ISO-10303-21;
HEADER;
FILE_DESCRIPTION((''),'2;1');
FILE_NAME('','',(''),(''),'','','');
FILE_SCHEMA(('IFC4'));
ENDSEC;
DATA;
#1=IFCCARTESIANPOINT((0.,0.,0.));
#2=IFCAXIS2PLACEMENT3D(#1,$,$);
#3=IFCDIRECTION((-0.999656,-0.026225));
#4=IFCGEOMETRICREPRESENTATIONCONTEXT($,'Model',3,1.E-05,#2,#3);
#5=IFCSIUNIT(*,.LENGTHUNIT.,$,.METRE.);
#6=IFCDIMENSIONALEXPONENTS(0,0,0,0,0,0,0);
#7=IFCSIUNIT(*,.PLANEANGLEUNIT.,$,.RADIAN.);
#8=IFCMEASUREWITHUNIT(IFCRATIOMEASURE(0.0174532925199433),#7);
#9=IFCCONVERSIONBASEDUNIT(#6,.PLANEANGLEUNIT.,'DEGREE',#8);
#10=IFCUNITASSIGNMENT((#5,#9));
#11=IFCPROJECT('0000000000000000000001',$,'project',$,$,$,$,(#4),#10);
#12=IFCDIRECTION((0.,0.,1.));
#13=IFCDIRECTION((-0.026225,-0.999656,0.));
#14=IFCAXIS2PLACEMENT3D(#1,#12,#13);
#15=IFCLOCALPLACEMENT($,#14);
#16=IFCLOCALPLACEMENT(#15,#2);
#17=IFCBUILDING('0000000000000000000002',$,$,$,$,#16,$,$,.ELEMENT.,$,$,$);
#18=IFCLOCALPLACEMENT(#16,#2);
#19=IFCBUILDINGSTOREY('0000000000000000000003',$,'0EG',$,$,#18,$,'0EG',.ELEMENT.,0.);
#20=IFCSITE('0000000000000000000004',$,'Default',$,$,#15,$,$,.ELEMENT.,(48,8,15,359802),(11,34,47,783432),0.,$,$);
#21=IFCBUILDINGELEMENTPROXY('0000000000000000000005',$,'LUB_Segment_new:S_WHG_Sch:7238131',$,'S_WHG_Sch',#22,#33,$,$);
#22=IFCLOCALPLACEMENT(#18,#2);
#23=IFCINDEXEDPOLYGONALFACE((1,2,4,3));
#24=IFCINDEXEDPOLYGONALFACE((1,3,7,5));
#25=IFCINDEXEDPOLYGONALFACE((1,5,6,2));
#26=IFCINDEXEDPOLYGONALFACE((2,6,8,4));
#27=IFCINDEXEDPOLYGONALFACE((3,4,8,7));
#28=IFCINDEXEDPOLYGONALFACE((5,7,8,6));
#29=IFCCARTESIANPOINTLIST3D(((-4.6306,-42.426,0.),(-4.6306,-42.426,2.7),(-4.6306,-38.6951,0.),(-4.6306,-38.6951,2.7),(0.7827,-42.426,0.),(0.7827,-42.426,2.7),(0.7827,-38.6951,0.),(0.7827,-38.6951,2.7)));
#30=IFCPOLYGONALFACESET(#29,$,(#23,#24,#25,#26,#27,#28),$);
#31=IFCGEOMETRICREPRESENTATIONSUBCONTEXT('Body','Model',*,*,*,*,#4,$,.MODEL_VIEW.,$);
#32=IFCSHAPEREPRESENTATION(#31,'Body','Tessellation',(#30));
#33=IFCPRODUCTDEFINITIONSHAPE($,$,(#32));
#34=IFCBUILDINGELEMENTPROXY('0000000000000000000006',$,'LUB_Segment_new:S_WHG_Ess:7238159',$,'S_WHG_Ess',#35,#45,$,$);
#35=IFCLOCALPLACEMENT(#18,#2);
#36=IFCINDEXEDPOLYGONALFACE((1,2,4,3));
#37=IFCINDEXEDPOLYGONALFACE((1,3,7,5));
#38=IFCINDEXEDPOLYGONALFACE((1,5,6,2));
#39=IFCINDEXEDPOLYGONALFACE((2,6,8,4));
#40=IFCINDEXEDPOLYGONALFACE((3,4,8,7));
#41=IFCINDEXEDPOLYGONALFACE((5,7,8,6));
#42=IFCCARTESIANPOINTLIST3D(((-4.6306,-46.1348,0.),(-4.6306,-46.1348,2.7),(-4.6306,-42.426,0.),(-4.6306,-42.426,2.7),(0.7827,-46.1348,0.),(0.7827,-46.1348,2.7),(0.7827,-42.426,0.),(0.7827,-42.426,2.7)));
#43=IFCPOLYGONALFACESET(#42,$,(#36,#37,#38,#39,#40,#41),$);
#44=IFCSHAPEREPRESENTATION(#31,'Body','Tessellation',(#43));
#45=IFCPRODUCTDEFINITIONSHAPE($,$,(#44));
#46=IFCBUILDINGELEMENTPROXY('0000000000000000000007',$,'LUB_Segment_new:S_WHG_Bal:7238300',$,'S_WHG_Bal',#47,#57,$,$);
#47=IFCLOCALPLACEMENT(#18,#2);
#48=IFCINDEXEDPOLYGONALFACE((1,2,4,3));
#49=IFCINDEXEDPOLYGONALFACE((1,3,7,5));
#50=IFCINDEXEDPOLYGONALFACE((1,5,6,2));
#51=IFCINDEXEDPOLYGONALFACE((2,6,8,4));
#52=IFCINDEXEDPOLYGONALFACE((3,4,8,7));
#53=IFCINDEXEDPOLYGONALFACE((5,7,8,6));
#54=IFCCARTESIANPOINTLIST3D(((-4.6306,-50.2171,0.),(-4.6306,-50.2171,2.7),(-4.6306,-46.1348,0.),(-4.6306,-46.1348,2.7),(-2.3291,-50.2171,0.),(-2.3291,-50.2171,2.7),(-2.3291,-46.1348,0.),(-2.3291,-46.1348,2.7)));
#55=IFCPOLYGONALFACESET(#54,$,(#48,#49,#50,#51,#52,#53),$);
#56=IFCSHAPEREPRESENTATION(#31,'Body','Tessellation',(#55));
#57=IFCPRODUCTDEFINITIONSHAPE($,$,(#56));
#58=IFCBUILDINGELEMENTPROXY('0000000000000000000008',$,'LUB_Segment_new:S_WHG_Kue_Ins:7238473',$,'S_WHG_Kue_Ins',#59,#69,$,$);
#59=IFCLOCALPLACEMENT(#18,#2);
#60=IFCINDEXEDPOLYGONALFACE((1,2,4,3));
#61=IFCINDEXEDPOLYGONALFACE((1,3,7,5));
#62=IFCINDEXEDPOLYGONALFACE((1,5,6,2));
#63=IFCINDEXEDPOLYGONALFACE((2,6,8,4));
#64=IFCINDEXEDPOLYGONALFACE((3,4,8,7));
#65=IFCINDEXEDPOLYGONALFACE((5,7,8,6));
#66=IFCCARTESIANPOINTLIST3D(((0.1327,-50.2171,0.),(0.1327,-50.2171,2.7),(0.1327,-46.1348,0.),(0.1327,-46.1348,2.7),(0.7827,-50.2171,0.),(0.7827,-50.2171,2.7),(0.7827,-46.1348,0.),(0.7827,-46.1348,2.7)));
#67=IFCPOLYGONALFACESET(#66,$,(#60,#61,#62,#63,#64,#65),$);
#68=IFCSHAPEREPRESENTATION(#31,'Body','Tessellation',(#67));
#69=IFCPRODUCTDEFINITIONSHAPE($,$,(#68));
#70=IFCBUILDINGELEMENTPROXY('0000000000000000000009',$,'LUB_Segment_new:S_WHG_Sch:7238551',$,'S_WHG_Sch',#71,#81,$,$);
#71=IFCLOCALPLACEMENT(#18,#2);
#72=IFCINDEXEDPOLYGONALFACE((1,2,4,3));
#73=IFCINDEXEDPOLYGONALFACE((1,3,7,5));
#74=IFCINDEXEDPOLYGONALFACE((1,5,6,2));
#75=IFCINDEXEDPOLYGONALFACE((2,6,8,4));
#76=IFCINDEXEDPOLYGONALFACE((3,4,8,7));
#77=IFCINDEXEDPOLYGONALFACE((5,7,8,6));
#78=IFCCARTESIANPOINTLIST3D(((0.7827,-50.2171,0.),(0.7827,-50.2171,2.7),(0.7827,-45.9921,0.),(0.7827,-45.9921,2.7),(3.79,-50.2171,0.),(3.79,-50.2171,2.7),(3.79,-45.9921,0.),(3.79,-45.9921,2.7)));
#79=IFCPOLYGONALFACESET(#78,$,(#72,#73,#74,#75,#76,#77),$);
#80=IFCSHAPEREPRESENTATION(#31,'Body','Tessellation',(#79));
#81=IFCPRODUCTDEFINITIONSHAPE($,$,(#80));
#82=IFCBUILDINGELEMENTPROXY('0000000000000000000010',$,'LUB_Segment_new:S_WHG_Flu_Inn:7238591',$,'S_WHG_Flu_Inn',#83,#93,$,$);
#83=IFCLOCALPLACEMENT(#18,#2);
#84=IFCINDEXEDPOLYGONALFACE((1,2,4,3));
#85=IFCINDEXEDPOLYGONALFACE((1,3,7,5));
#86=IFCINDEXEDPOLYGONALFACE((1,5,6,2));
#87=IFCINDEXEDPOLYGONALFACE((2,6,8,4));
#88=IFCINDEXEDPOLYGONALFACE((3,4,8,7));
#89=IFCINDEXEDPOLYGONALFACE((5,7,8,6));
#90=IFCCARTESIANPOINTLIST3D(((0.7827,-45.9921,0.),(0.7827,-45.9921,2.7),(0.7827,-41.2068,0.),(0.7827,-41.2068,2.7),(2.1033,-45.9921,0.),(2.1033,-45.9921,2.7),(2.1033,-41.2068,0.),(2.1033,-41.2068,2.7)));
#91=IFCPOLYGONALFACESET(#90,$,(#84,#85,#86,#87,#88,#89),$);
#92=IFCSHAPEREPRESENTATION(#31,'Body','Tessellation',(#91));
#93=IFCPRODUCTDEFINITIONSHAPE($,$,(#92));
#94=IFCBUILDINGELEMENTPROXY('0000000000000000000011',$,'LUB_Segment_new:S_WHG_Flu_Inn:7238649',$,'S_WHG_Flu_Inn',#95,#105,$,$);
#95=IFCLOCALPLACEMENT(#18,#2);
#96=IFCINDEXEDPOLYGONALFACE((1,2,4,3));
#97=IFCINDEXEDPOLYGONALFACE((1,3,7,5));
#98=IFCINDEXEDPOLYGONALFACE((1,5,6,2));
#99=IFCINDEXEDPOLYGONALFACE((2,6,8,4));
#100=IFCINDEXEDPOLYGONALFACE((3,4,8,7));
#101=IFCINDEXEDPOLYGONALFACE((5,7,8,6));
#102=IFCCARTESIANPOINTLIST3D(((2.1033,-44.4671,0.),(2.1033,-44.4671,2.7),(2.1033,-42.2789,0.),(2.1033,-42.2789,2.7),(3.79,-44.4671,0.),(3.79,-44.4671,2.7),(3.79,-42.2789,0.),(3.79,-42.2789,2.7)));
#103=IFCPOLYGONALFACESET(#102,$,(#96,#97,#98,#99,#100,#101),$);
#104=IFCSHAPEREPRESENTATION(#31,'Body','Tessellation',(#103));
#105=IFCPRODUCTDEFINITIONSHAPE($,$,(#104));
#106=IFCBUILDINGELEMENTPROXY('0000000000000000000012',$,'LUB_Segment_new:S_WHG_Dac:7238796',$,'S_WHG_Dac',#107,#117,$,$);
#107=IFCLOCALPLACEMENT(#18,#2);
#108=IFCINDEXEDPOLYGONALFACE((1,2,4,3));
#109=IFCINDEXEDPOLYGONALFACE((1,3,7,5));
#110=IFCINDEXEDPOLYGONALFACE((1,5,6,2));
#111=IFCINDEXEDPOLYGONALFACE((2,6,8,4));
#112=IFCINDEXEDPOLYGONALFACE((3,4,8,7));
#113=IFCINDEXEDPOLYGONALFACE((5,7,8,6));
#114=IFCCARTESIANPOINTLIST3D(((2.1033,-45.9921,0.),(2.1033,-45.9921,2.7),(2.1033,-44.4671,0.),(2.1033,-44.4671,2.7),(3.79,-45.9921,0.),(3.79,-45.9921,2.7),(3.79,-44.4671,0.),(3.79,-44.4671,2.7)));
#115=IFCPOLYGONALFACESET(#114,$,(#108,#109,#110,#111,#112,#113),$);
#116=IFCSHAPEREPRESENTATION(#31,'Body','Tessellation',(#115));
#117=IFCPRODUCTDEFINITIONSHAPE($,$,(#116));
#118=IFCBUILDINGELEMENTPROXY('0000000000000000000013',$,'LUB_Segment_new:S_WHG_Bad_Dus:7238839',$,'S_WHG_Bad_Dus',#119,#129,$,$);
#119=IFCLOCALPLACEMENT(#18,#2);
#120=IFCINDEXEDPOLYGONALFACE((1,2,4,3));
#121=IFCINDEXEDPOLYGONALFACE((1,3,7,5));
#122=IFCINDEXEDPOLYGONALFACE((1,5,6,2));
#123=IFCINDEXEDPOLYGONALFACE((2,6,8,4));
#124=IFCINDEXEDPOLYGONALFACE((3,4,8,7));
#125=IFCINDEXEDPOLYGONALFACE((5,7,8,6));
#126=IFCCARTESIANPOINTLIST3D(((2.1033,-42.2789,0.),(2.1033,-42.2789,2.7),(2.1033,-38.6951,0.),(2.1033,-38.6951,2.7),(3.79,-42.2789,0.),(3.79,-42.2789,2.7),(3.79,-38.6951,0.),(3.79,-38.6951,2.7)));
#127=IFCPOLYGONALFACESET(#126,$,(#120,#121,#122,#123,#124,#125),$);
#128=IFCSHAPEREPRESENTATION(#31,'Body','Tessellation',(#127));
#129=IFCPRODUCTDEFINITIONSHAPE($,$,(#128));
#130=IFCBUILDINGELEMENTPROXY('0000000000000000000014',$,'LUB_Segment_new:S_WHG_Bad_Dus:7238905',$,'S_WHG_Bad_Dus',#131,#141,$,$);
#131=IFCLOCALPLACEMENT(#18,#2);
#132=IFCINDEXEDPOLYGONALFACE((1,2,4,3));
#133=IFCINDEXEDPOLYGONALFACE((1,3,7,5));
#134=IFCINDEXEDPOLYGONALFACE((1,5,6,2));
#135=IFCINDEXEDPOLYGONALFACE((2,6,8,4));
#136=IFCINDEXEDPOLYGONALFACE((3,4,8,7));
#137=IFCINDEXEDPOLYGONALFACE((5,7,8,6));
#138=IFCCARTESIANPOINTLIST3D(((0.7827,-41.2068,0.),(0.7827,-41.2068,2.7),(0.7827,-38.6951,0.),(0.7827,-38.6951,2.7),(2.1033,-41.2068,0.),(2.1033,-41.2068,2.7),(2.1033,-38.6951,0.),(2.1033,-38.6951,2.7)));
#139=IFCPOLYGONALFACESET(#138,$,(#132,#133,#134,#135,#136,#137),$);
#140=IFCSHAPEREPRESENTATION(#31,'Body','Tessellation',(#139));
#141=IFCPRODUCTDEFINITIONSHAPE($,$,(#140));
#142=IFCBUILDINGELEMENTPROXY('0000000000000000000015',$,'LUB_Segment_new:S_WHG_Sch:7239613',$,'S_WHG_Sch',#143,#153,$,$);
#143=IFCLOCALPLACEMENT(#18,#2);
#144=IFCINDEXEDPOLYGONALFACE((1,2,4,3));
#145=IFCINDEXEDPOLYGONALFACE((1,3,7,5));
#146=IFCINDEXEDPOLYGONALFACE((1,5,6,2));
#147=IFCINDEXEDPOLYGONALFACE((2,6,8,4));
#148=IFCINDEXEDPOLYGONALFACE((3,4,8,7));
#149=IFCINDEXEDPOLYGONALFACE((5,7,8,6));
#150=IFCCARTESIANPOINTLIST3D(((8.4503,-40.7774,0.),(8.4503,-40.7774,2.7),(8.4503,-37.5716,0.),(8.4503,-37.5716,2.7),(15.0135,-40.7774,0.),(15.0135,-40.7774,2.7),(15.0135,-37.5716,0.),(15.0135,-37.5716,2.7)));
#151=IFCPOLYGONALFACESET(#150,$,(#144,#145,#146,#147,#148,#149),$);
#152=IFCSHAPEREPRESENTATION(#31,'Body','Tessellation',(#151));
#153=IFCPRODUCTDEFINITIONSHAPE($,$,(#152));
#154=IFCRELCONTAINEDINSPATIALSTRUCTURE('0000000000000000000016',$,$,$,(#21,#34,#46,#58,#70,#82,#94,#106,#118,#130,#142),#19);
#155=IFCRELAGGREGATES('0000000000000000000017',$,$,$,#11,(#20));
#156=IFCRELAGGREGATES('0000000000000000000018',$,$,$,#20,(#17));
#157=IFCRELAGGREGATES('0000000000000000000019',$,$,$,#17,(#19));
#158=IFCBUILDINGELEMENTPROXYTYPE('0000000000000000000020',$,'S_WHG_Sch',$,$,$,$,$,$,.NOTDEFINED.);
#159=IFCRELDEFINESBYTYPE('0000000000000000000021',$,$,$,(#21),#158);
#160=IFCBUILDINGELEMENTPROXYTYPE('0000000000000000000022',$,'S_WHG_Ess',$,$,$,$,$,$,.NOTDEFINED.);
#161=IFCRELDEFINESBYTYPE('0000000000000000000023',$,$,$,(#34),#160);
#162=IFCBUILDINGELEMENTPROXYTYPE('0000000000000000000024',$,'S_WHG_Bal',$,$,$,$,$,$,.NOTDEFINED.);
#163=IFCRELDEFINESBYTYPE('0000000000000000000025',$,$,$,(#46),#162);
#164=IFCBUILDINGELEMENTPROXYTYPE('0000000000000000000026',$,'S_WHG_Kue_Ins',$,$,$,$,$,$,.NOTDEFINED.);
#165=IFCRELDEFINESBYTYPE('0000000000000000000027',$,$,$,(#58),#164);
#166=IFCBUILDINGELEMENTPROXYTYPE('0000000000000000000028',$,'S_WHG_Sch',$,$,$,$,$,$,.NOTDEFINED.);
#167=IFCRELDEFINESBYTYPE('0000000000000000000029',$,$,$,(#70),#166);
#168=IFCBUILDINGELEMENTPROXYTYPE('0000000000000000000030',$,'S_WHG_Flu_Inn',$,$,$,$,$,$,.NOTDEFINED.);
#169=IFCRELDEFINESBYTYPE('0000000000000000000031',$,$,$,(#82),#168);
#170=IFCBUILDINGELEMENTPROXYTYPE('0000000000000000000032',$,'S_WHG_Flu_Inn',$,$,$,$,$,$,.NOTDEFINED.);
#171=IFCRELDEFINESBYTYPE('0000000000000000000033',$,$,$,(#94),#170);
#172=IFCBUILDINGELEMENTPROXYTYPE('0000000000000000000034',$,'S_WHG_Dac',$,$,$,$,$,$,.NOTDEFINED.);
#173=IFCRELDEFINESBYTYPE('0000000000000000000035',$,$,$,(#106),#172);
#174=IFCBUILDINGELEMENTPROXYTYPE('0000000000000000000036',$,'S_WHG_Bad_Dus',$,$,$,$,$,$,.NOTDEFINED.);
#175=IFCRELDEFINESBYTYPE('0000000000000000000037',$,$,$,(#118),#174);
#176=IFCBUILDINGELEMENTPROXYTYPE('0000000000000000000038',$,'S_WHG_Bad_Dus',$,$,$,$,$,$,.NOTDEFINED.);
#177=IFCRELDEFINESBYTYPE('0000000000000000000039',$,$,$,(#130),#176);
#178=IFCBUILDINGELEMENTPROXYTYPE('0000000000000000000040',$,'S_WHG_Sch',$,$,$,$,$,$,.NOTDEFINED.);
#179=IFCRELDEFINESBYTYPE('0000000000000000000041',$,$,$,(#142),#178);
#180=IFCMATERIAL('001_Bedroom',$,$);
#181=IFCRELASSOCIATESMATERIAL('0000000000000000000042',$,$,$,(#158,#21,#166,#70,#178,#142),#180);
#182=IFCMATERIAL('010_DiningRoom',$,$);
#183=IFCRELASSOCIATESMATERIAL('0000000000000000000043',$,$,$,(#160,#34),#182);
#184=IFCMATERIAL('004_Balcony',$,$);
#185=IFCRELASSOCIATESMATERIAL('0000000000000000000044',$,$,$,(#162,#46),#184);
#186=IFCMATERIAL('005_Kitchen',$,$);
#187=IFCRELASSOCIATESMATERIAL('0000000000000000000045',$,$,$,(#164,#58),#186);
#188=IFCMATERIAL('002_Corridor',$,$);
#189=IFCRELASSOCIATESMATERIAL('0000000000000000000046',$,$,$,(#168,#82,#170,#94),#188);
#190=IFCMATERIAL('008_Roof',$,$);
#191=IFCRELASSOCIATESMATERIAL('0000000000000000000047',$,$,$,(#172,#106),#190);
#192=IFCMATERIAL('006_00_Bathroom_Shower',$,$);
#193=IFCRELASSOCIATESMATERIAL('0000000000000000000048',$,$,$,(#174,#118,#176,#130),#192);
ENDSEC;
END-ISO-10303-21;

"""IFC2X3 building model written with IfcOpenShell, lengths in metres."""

from ifc_helpers import new_model, entity, si_unit, converted_unit, direction, frame, frame_2d, origin, origin_2d_with_axis, place, context, subcontext, project, spatial, rectangle, extrude, source, transform, mapped, material, type_object, type_shapes, element, save


model = new_model("IFC2X3")

# Units and contexts
model_context = context("Model", 3, precision=1e-05, world=origin(), true_north=direction((-0.999656, -0.026225)))
body_context = subcontext(model_context, "Body", "Model", "MODEL_VIEW")
ifc_project = project(units=[si_unit("LENGTHUNIT", "METRE"), converted_unit("PLANEANGLEUNIT", "DEGREE", entity("IfcRatioMeasure", 0.0174532925199433), si_unit("PLANEANGLEUNIT", "RADIAN"), dimensions=[0, 0, 0, 0, 0, 0, 0])], contexts=[model_context])

# Site, building, storey
site_placement = place(None, frame((0.0, 0.0, 0.0), z_axis=(0.0, 0.0, 1.0), x_axis=(-0.026225, -0.999656, 0.0)))
site = spatial("IfcSite", under=ifc_project, at=site_placement, Name="Default", CompositionType="ELEMENT", RefLatitude=(48, 8, 15, 359802), RefLongitude=(11, 34, 47, 783432), RefElevation=0.0)
building_placement = place(site_placement, origin())
building = spatial("IfcBuilding", under=site, at=building_placement, CompositionType="ELEMENT")
storey_placement = place(building_placement, origin())
storey = spatial("IfcBuildingStorey", under=building, at=storey_placement, Name="0EG", LongName="0EG", CompositionType="ELEMENT", Elevation=0.0)

# Building element proxies
ifc_material_1 = material(Name="001_Bedroom")
building_element_proxy_type_1 = type_object("IfcBuildingElementProxyType", Name="S_WHG_Sch", PredefinedType="NOTDEFINED", material=ifc_material_1)
shared_shape_1 = source(origin(), body_context, "Body", "SweptSolid", [
    extrude(rectangle(XDim=5.4132, YDim=3.7309, at=origin_2d_with_axis()), frame((0.0, 0.0, 0.0), z_axis=(0.0, 0.0, 1.0), x_axis=(-1.0, 0.0, 0.0)), (0.0, 0.0, 1.0), 2.7),
])
type_shapes(building_element_proxy_type_1, [shared_shape_1])
proxy_1_placement = place(storey_placement, frame((-1.924, -40.5605, 0.0)))
element("IfcBuildingElementProxy", 1, at=proxy_1_placement, inside=storey, type_object=building_element_proxy_type_1, material=ifc_material_1, Name="LUB_Segment_new:S_WHG_Sch:7238131", ObjectType="S_WHG_Sch", context=body_context, shape_type="MappedRepresentation", body=[
    mapped(shared_shape_1, transform((0.0, 0.0, 0.0), scale=1.0)),
])
ifc_material_2 = material(Name="010_DiningRoom")
building_element_proxy_type_2 = type_object("IfcBuildingElementProxyType", Name="S_WHG_Ess", PredefinedType="NOTDEFINED", material=ifc_material_2)
shared_shape_2 = source(origin(), body_context, "Body", "SweptSolid", [
    extrude(rectangle(XDim=5.4132, YDim=3.7088, at=origin_2d_with_axis()), frame((0.0, 0.0, 0.0), z_axis=(0.0, 0.0, 1.0), x_axis=(-1.0, 0.0, 0.0)), (0.0, 0.0, 1.0), 2.7),
])
type_shapes(building_element_proxy_type_2, [shared_shape_2])
proxy_2_placement = place(storey_placement, frame((-1.924, -44.2804, 0.0)))
element("IfcBuildingElementProxy", 2, at=proxy_2_placement, inside=storey, type_object=building_element_proxy_type_2, material=ifc_material_2, Name="LUB_Segment_new:S_WHG_Ess:7238159", ObjectType="S_WHG_Ess", context=body_context, shape_type="MappedRepresentation", body=[
    mapped(shared_shape_2, transform((0.0, 0.0, 0.0), scale=1.0)),
])
ifc_material_3 = material(Name="004_Balcony")
building_element_proxy_type_3 = type_object("IfcBuildingElementProxyType", Name="S_WHG_Bal", PredefinedType="NOTDEFINED", material=ifc_material_3)
shared_shape_3 = source(origin(), body_context, "Body", "SweptSolid", [
    extrude(rectangle(XDim=4.0824, YDim=2.3015, at=origin_2d_with_axis()), frame((0.0, 0.0, 0.0), z_axis=(0.0, 0.0, 1.0), x_axis=(0.0, 1.0, 0.0)), (0.0, 0.0, 1.0), 2.7),
])
type_shapes(building_element_proxy_type_3, [shared_shape_3])
proxy_3_placement = place(storey_placement, frame((-3.4798, -48.176, 0.0)))
element("IfcBuildingElementProxy", 3, at=proxy_3_placement, inside=storey, type_object=building_element_proxy_type_3, material=ifc_material_3, Name="LUB_Segment_new:S_WHG_Bal:7238300", ObjectType="S_WHG_Bal", context=body_context, shape_type="MappedRepresentation", body=[
    mapped(shared_shape_3, transform((0.0, 0.0, 0.0), scale=1.0)),
])
ifc_material_4 = material(Name="005_Kitchen")
building_element_proxy_type_4 = type_object("IfcBuildingElementProxyType", Name="S_WHG_Kue_Ins", PredefinedType="NOTDEFINED", material=ifc_material_4)
shared_shape_4 = source(origin(), body_context, "Body", "SweptSolid", [
    extrude(rectangle(XDim=4.0824, YDim=0.65, at=origin_2d_with_axis()), frame((0.0, 0.0, 0.0), z_axis=(0.0, 0.0, 1.0), x_axis=(0.0, 1.0, 0.0)), (0.0, 0.0, 1.0), 2.7),
])
type_shapes(building_element_proxy_type_4, [shared_shape_4])
proxy_4_placement = place(storey_placement, frame((0.4577, -48.176, 0.0)))
element("IfcBuildingElementProxy", 4, at=proxy_4_placement, inside=storey, type_object=building_element_proxy_type_4, material=ifc_material_4, Name="LUB_Segment_new:S_WHG_Kue_Ins:7238473", ObjectType="S_WHG_Kue_Ins", context=body_context, shape_type="MappedRepresentation", body=[
    mapped(shared_shape_4, transform((0.0, 0.0, 0.0), scale=1.0)),
])
building_element_proxy_type_5 = type_object("IfcBuildingElementProxyType", Name="S_WHG_Sch", PredefinedType="NOTDEFINED", material=ifc_material_1)
shared_shape_5 = source(origin(), body_context, "Body", "SweptSolid", [
    extrude(rectangle(XDim=4.225, YDim=3.0074, at=origin_2d_with_axis()), frame((0.0, 0.0, 0.0), z_axis=(0.0, 0.0, 1.0), x_axis=(0.0, 1.0, 0.0)), (0.0, 0.0, 1.0), 2.7),
])
type_shapes(building_element_proxy_type_5, [shared_shape_5])
proxy_5_placement = place(storey_placement, frame((2.2863, -48.1046, 0.0)))
element("IfcBuildingElementProxy", 5, at=proxy_5_placement, inside=storey, type_object=building_element_proxy_type_5, material=ifc_material_1, Name="LUB_Segment_new:S_WHG_Sch:7238551", ObjectType="S_WHG_Sch", context=body_context, shape_type="MappedRepresentation", body=[
    mapped(shared_shape_5, transform((0.0, 0.0, 0.0), scale=1.0)),
])
ifc_material_5 = material(Name="002_Corridor")
building_element_proxy_type_6 = type_object("IfcBuildingElementProxyType", Name="S_WHG_Flu_Inn", PredefinedType="NOTDEFINED", material=ifc_material_5)
shared_shape_6 = source(origin(), body_context, "Body", "SweptSolid", [
    extrude(rectangle(XDim=4.7853, YDim=1.3206, at=origin_2d_with_axis()), frame((0.0, 0.0, 0.0), z_axis=(0.0, 0.0, 1.0), x_axis=(0.0, 1.0, 0.0)), (0.0, 0.0, 1.0), 2.7),
])
type_shapes(building_element_proxy_type_6, [shared_shape_6])
proxy_6_placement = place(storey_placement, frame((1.443, -43.5995, 0.0)))
element("IfcBuildingElementProxy", 6, at=proxy_6_placement, inside=storey, type_object=building_element_proxy_type_6, material=ifc_material_5, Name="LUB_Segment_new:S_WHG_Flu_Inn:7238591", ObjectType="S_WHG_Flu_Inn", context=body_context, shape_type="MappedRepresentation", body=[
    mapped(shared_shape_6, transform((0.0, 0.0, 0.0), scale=1.0)),
])
building_element_proxy_type_7 = type_object("IfcBuildingElementProxyType", Name="S_WHG_Flu_Inn", PredefinedType="NOTDEFINED", material=ifc_material_5)
shared_shape_7 = source(origin(), body_context, "Body", "SweptSolid", [
    extrude(rectangle(XDim=2.1882, YDim=1.6868, at=origin_2d_with_axis()), frame((0.0, 0.0, 0.0), z_axis=(0.0, 0.0, 1.0), x_axis=(0.0, 1.0, 0.0)), (0.0, 0.0, 1.0), 2.7),
])
type_shapes(building_element_proxy_type_7, [shared_shape_7])
proxy_7_placement = place(storey_placement, frame((2.9466, -43.373, 0.0)))
element("IfcBuildingElementProxy", 7, at=proxy_7_placement, inside=storey, type_object=building_element_proxy_type_7, material=ifc_material_5, Name="LUB_Segment_new:S_WHG_Flu_Inn:7238649", ObjectType="S_WHG_Flu_Inn", context=body_context, shape_type="MappedRepresentation", body=[
    mapped(shared_shape_7, transform((0.0, 0.0, 0.0), scale=1.0)),
])
ifc_material_6 = material(Name="008_Roof")
building_element_proxy_type_8 = type_object("IfcBuildingElementProxyType", Name="S_WHG_Dac", PredefinedType="NOTDEFINED", material=ifc_material_6)
shared_shape_8 = source(origin(), body_context, "Body", "SweptSolid", [
    extrude(rectangle(XDim=1.525, YDim=1.6868, at=origin_2d_with_axis()), frame((0.0, 0.0, 0.0), z_axis=(0.0, 0.0, 1.0), x_axis=(0.0, 1.0, 0.0)), (0.0, 0.0, 1.0), 2.7),
])
type_shapes(building_element_proxy_type_8, [shared_shape_8])
proxy_8_placement = place(storey_placement, frame((2.9466, -45.2296, 0.0)))
element("IfcBuildingElementProxy", 8, at=proxy_8_placement, inside=storey, type_object=building_element_proxy_type_8, material=ifc_material_6, Name="LUB_Segment_new:S_WHG_Dac:7238796", ObjectType="S_WHG_Dac", context=body_context, shape_type="MappedRepresentation", body=[
    mapped(shared_shape_8, transform((0.0, 0.0, 0.0), scale=1.0)),
])
ifc_material_7 = material(Name="006_00_Bathroom_Shower")
building_element_proxy_type_9 = type_object("IfcBuildingElementProxyType", Name="S_WHG_Bad_Dus", PredefinedType="NOTDEFINED", material=ifc_material_7)
shared_shape_9 = source(origin(), body_context, "Body", "SweptSolid", [
    extrude(rectangle(XDim=3.5838, YDim=1.6868, at=origin_2d_with_axis()), frame((0.0, 0.0, 0.0), z_axis=(0.0, 0.0, 1.0), x_axis=(0.0, 1.0, 0.0)), (0.0, 0.0, 1.0), 2.7),
])
type_shapes(building_element_proxy_type_9, [shared_shape_9])
proxy_9_placement = place(storey_placement, frame((2.9466, -40.487, 0.0)))
element("IfcBuildingElementProxy", 9, at=proxy_9_placement, inside=storey, type_object=building_element_proxy_type_9, material=ifc_material_7, Name="LUB_Segment_new:S_WHG_Bad_Dus:7238839", ObjectType="S_WHG_Bad_Dus", context=body_context, shape_type="MappedRepresentation", body=[
    mapped(shared_shape_9, transform((0.0, 0.0, 0.0), scale=1.0)),
])
building_element_proxy_type_10 = type_object("IfcBuildingElementProxyType", Name="S_WHG_Bad_Dus", PredefinedType="NOTDEFINED", material=ifc_material_7)
shared_shape_10 = source(origin(), body_context, "Body", "SweptSolid", [
    extrude(rectangle(XDim=2.5118, YDim=1.3206, at=frame_2d((0.0, 0.0), x_axis=(1.0, 0.0))), frame((0.0, 0.0, 0.0), z_axis=(0.0, 0.0, 1.0), x_axis=(0.0, 1.0, 0.0)), (0.0, 0.0, 1.0), 2.7),
])
type_shapes(building_element_proxy_type_10, [shared_shape_10])
proxy_10_placement = place(storey_placement, frame((1.443, -39.951, 0.0)))
element("IfcBuildingElementProxy", 10, at=proxy_10_placement, inside=storey, type_object=building_element_proxy_type_10, material=ifc_material_7, Name="LUB_Segment_new:S_WHG_Bad_Dus:7238905", ObjectType="S_WHG_Bad_Dus", context=body_context, shape_type="MappedRepresentation", body=[
    mapped(shared_shape_10, transform((0.0, 0.0, 0.0), scale=1.0)),
])
building_element_proxy_type_11 = type_object("IfcBuildingElementProxyType", Name="S_WHG_Sch", PredefinedType="NOTDEFINED", material=ifc_material_1)
shared_shape_11 = source(origin(), body_context, "Body", "SweptSolid", [
    extrude(rectangle(XDim=6.5632, YDim=3.2059, at=origin_2d_with_axis()), frame((0.0, 0.0, 0.0), z_axis=(0.0, 0.0, 1.0), x_axis=(-1.0, 0.0, 0.0)), (0.0, 0.0, 1.0), 2.7),
])
type_shapes(building_element_proxy_type_11, [shared_shape_11])
proxy_11_placement = place(storey_placement, frame((11.7319, -39.1745, 0.0)))
element("IfcBuildingElementProxy", 11, at=proxy_11_placement, inside=storey, type_object=building_element_proxy_type_11, material=ifc_material_1, Name="LUB_Segment_new:S_WHG_Sch:7239613", ObjectType="S_WHG_Sch", context=body_context, shape_type="MappedRepresentation", body=[
    mapped(shared_shape_11, transform((0.0, 0.0, 0.0), scale=1.0)),
])

save(model, "model.ifc")
